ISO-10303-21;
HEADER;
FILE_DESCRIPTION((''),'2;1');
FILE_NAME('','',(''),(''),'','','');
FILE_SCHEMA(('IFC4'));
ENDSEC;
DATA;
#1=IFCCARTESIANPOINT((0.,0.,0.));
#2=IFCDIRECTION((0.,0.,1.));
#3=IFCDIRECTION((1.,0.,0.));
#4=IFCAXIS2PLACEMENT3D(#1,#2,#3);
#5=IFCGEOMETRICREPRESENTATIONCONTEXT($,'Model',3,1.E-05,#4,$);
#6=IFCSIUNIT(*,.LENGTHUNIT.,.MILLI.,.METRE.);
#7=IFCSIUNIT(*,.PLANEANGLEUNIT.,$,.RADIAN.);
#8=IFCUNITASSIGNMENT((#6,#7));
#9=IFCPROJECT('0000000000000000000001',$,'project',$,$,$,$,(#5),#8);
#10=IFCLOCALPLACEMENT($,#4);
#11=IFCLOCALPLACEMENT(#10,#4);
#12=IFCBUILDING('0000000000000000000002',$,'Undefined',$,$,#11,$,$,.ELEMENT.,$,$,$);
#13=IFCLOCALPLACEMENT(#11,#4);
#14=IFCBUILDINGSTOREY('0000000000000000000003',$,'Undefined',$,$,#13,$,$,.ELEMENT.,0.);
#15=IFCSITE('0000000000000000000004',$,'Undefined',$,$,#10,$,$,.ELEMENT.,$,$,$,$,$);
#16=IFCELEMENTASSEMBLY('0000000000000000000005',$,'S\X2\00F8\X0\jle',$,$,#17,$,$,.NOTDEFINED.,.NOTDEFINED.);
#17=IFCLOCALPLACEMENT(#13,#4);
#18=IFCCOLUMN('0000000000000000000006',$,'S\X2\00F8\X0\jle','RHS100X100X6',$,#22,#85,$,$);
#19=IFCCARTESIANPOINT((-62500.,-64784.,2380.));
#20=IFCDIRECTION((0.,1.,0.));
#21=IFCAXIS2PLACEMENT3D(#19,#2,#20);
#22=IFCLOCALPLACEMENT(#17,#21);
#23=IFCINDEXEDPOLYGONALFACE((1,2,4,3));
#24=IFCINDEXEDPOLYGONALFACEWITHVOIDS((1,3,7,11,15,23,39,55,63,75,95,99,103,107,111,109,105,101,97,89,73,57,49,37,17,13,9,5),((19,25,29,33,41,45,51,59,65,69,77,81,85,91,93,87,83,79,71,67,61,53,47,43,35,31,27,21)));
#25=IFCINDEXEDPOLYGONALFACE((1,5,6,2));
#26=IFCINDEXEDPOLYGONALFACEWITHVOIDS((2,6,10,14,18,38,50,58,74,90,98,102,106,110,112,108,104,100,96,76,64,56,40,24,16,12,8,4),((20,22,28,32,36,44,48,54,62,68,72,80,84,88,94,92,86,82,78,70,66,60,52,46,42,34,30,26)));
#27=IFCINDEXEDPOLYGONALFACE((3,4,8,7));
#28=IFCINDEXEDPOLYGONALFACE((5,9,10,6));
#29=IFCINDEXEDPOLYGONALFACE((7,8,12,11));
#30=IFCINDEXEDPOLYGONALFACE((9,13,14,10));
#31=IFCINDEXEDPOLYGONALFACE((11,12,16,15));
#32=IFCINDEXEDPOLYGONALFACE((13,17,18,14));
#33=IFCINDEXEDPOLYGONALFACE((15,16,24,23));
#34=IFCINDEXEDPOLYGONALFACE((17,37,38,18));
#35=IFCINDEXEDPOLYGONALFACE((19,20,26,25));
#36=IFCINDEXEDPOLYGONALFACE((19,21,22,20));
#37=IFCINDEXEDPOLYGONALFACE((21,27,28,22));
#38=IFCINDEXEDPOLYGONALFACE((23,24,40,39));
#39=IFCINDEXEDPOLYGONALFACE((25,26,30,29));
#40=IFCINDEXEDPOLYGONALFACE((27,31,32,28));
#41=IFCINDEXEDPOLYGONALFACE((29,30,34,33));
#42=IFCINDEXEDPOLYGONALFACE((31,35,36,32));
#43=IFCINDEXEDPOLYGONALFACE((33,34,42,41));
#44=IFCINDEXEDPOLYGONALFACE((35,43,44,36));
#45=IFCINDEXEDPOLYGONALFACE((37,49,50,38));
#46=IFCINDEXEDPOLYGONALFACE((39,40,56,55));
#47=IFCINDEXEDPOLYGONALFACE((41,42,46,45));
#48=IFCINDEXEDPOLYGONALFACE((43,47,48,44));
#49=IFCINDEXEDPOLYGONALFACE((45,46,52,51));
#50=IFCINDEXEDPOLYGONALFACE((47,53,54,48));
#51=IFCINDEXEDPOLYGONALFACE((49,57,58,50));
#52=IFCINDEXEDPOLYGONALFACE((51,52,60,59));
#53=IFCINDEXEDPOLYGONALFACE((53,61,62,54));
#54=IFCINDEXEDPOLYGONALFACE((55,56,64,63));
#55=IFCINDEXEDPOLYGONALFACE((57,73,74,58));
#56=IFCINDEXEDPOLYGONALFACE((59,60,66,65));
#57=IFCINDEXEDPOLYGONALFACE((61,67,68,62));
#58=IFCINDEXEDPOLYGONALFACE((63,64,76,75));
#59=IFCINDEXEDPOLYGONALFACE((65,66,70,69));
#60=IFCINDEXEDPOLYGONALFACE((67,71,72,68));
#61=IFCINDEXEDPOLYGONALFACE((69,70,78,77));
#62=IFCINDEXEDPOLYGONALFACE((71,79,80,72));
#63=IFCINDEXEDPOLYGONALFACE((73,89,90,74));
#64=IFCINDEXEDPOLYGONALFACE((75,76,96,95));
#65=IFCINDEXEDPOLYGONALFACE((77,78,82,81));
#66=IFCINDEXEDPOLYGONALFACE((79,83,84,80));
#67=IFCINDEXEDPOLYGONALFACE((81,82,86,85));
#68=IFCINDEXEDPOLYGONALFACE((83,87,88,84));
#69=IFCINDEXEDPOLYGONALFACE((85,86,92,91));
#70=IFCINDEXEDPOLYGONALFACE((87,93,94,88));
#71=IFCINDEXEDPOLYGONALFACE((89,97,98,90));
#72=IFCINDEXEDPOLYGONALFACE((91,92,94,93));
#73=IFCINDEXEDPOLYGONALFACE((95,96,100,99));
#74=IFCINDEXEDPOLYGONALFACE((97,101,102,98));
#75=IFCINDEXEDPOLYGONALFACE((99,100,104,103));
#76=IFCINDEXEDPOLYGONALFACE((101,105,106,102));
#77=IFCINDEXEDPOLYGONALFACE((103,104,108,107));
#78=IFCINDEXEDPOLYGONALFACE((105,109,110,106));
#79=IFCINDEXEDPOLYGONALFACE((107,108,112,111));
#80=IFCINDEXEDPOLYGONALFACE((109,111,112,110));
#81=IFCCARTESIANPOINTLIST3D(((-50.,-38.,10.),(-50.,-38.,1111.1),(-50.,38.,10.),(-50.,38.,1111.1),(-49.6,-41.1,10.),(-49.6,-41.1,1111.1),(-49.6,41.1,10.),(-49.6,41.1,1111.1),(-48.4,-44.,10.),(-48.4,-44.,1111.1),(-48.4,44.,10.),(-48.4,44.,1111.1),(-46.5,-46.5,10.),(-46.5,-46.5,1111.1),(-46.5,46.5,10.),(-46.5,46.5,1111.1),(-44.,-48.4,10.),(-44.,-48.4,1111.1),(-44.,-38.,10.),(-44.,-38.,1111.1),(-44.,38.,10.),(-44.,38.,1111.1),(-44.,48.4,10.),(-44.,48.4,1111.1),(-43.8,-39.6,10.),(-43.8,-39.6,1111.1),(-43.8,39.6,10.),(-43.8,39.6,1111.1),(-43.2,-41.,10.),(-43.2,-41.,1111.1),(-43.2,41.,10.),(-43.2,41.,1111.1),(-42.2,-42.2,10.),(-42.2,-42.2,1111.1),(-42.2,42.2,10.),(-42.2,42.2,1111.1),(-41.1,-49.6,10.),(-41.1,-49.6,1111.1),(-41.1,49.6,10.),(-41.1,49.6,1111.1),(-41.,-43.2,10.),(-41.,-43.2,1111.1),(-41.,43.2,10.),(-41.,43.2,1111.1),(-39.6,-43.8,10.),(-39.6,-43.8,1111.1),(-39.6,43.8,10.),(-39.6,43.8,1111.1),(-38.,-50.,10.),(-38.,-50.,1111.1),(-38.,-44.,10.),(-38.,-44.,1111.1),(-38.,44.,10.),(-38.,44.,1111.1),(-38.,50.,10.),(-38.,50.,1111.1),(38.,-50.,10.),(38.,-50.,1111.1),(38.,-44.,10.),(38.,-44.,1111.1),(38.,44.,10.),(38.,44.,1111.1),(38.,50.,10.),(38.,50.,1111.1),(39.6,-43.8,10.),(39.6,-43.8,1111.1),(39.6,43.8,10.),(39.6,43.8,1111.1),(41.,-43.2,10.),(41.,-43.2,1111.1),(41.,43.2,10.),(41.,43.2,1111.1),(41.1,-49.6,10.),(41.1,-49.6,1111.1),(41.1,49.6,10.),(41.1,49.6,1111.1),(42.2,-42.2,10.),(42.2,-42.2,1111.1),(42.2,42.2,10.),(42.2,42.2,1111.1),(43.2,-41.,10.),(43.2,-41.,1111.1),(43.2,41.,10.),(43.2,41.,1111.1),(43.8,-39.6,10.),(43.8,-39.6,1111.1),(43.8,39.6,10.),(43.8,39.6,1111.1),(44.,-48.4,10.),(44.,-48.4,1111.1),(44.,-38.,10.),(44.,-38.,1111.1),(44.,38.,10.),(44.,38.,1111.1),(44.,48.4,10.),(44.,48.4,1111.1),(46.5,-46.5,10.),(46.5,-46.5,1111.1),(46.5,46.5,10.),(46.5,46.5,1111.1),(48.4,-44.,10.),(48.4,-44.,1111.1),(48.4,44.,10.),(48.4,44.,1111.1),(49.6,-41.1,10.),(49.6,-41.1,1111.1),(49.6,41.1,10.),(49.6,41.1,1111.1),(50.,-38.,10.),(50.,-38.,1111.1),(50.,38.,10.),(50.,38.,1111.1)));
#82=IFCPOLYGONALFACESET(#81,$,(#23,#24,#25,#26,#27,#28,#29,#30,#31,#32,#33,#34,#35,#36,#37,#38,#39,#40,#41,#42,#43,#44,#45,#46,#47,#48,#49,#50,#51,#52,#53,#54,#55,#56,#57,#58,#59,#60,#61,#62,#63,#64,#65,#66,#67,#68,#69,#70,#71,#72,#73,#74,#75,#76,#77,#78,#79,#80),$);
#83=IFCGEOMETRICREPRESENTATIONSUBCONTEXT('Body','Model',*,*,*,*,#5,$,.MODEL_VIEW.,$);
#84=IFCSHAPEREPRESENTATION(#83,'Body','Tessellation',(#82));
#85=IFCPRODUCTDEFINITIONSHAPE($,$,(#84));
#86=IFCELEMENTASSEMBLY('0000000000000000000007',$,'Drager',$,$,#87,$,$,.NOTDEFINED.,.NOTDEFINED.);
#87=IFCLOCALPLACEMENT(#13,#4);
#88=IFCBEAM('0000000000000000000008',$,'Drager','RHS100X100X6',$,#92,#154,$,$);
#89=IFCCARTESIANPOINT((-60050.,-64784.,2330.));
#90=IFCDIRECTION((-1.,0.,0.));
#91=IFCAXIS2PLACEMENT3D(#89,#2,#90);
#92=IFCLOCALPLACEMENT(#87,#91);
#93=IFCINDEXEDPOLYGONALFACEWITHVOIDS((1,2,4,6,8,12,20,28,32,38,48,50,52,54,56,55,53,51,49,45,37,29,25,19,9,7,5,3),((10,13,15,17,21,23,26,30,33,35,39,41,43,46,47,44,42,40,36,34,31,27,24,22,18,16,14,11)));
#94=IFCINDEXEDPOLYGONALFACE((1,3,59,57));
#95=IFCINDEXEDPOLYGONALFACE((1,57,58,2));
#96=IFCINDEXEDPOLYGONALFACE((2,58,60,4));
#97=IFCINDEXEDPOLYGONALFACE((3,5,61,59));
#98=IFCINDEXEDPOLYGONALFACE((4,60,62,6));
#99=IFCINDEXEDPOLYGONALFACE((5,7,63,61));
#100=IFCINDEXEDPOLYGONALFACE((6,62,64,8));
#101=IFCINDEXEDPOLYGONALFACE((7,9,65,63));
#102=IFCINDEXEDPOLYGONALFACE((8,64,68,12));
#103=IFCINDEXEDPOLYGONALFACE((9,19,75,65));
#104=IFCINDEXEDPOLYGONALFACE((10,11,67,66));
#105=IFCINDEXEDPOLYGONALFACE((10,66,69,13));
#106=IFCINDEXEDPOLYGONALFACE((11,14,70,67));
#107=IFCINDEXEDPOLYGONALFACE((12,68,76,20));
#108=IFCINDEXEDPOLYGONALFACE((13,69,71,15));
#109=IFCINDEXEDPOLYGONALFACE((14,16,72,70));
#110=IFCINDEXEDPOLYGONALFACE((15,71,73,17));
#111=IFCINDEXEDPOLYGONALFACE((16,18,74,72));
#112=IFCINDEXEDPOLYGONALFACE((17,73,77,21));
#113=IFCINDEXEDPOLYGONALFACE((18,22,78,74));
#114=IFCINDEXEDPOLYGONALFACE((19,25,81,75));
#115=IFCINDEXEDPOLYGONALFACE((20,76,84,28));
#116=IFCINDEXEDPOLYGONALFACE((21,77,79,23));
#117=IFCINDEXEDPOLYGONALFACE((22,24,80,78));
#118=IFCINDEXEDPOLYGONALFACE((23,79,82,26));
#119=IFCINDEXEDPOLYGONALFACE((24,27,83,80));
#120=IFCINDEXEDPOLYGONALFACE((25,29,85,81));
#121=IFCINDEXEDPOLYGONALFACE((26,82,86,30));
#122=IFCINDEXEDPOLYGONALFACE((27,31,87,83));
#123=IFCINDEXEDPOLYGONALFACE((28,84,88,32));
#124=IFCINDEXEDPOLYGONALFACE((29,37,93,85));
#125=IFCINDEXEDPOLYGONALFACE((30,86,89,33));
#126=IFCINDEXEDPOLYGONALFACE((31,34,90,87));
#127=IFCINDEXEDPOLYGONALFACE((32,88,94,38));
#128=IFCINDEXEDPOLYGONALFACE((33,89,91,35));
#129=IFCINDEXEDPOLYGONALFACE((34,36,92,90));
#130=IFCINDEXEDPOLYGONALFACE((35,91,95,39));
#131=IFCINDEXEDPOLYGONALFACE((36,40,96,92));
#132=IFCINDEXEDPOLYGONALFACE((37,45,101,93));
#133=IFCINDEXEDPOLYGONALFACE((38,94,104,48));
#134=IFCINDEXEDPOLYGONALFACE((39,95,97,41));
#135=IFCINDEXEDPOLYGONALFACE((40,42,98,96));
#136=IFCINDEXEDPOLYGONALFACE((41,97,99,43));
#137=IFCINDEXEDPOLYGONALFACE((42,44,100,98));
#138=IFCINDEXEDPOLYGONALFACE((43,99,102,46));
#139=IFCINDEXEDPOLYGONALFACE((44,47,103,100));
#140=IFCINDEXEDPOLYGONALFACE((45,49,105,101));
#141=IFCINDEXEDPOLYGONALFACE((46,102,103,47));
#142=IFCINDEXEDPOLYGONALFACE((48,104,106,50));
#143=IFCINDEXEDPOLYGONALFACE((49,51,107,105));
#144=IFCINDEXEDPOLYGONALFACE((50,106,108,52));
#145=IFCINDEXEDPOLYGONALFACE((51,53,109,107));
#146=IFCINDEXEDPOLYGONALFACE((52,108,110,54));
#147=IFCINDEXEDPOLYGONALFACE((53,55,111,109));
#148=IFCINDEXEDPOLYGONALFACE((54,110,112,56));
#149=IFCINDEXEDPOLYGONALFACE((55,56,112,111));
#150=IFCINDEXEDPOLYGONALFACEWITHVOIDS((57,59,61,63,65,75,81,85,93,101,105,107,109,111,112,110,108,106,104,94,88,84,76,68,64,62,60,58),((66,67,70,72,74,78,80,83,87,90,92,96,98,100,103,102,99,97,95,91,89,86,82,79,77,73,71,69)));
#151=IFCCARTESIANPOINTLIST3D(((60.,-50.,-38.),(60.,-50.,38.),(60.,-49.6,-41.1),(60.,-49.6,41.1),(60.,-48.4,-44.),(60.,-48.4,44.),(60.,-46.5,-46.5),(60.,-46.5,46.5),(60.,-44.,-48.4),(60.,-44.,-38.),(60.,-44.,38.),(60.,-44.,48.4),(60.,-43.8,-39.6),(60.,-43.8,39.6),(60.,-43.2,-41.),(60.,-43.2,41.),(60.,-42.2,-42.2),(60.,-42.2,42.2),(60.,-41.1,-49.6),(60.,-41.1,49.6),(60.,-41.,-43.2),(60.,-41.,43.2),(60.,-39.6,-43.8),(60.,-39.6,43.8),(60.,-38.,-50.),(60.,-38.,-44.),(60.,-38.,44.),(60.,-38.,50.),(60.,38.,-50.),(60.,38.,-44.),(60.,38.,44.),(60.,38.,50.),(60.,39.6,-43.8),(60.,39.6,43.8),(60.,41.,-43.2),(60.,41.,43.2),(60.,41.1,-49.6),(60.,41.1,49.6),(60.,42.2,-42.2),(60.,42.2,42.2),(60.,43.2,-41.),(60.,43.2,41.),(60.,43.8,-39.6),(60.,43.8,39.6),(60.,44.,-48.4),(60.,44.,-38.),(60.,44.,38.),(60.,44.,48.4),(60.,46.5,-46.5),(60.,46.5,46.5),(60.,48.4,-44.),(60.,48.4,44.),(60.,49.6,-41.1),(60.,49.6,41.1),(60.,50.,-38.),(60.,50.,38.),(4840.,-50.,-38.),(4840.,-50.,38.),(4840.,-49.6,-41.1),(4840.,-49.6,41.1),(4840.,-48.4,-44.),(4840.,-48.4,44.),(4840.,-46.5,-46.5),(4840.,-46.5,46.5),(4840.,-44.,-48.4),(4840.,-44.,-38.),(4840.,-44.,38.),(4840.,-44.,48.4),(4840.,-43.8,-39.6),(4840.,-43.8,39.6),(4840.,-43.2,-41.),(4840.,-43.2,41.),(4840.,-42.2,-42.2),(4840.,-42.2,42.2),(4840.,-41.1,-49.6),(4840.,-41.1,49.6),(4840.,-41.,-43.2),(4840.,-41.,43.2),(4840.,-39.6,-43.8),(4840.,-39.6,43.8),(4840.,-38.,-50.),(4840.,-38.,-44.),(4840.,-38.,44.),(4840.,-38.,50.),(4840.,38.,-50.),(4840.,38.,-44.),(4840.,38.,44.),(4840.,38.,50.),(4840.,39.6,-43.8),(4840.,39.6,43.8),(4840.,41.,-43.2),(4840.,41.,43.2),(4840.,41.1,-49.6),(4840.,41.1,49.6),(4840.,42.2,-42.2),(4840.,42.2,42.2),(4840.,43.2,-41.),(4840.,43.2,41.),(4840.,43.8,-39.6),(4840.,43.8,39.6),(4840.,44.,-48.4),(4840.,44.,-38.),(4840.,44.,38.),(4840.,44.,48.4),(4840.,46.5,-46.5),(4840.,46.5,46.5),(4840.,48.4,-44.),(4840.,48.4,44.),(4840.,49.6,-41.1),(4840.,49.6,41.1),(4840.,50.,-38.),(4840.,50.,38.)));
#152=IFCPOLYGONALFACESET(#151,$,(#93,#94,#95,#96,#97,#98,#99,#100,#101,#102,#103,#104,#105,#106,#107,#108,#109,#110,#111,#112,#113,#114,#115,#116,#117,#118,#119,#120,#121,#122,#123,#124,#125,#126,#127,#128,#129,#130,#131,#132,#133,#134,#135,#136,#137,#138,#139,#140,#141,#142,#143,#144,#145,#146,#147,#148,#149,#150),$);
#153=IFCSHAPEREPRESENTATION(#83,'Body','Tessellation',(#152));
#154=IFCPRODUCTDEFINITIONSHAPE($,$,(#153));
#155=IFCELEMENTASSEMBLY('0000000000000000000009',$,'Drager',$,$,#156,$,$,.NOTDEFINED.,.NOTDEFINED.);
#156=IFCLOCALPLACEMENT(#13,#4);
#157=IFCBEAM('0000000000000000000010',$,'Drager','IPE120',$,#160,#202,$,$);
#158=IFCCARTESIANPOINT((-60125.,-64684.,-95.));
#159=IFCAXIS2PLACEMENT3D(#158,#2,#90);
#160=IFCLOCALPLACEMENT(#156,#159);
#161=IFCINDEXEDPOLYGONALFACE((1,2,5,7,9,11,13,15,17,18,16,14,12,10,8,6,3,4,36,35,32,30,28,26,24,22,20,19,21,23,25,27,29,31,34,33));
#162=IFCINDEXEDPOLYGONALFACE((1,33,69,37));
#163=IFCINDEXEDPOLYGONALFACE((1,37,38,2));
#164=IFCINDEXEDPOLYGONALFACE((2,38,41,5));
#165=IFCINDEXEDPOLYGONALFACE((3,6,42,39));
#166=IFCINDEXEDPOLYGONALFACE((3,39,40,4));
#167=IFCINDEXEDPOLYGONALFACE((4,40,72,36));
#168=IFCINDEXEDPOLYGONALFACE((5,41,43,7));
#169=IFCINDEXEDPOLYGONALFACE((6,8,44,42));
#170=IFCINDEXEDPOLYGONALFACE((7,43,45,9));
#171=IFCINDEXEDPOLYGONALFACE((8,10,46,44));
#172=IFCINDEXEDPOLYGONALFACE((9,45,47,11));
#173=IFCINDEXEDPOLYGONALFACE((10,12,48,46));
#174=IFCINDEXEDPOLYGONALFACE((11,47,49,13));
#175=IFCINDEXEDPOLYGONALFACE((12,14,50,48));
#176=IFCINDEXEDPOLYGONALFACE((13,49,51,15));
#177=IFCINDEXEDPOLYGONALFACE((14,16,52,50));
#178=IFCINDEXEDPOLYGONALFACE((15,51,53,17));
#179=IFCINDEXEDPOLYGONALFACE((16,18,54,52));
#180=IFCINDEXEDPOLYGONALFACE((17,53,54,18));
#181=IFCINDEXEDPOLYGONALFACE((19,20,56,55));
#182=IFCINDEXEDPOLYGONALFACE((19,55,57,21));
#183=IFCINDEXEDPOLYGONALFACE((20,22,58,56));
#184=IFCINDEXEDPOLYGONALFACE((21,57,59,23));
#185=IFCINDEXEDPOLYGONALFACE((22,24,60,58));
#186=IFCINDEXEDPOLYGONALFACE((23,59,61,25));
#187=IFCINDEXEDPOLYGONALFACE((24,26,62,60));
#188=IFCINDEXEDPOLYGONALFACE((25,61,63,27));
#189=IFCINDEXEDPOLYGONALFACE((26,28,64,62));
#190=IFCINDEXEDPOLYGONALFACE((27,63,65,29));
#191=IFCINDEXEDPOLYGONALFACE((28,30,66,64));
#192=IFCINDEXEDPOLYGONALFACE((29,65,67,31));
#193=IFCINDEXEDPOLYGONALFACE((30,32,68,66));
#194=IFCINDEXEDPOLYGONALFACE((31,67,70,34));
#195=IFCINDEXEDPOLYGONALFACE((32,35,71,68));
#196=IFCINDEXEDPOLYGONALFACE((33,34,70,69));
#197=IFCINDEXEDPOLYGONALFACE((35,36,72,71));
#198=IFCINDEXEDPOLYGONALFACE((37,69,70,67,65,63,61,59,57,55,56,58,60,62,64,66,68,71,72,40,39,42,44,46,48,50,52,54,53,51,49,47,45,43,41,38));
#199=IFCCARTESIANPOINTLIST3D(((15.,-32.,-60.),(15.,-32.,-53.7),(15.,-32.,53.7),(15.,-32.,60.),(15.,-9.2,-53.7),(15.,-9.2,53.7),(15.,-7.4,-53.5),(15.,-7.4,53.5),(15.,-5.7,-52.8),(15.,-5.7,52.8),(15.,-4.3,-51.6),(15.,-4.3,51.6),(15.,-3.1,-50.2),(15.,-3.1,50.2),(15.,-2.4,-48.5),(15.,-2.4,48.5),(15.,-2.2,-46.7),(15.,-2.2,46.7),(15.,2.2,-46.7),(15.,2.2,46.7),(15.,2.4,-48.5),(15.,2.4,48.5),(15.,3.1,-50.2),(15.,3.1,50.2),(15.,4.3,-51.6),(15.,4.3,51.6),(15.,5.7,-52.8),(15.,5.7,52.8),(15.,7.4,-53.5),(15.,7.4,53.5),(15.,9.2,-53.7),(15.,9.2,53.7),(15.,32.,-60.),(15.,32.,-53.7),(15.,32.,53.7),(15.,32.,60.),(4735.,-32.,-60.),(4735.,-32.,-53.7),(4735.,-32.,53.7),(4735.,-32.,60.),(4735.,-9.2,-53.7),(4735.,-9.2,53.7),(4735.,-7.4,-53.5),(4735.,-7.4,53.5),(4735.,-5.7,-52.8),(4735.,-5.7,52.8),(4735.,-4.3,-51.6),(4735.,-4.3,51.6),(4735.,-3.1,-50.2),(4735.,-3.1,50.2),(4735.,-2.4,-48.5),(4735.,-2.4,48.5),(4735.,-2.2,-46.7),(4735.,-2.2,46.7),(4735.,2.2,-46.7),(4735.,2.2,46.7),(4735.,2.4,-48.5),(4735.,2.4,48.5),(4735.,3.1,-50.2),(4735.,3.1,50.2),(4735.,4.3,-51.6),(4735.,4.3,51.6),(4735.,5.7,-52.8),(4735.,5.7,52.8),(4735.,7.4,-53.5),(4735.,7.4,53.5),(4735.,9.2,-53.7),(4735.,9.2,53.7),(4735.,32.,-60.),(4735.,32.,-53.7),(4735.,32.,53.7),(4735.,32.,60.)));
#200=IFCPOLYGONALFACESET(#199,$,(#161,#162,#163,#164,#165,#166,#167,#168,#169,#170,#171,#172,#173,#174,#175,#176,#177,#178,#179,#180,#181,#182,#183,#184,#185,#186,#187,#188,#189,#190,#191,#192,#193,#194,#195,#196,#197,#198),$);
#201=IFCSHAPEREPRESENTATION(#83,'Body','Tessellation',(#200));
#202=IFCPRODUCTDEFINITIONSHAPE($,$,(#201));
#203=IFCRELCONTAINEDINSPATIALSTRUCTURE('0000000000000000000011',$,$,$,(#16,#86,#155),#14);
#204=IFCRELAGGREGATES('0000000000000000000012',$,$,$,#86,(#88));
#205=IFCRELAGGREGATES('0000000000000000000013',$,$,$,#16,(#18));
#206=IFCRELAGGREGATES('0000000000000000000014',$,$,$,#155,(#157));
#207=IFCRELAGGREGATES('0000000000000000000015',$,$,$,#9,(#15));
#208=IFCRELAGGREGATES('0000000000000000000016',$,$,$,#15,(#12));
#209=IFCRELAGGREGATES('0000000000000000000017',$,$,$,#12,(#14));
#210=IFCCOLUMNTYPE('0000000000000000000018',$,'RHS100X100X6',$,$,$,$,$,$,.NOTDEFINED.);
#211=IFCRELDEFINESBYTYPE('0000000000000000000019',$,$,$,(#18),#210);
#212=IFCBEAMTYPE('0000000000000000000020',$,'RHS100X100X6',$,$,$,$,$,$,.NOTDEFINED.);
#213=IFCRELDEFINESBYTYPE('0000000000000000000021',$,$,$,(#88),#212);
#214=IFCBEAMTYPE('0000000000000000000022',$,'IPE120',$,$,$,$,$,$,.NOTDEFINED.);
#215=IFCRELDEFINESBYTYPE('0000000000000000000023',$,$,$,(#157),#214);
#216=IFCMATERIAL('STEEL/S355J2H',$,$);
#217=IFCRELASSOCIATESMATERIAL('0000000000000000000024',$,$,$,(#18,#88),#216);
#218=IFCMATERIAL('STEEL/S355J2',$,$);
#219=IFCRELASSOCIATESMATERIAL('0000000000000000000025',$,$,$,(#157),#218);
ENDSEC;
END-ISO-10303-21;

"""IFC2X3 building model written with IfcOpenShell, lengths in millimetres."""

from ifc_helpers import new_model, si_unit, frame, origin_with_axes, origin_2d_with_axis, place, context, subcontext, project, spatial, hollow_rectangle, i_section, extrude, clip, halfspace, material, type_object, element, aggregate, save


model = new_model("IFC2X3")

# Units and contexts
model_context = context("Model", 3, precision=1e-05, world=origin_with_axes())
body_context = subcontext(model_context, "Body", "Model", "MODEL_VIEW")
ifc_project = project(units=[si_unit("LENGTHUNIT", "METRE", prefix="MILLI"), si_unit("PLANEANGLEUNIT", "RADIAN")], contexts=[model_context])

# Site, building, storey
site_placement = place(None, origin_with_axes())
site = spatial("IfcSite", under=ifc_project, at=site_placement, Name="Undefined", CompositionType="ELEMENT")
building_placement = place(site_placement, origin_with_axes())
building = spatial("IfcBuilding", under=site, at=building_placement, Name="Undefined", CompositionType="ELEMENT")
storey_placement = place(building_placement, origin_with_axes())
storey = spatial("IfcBuildingStorey", under=building, at=storey_placement, Name="Undefined", CompositionType="ELEMENT", Elevation=0.0)

# Element assembly, column
assembly_1_placement = place(storey_placement, origin_with_axes())
assembly_1 = element("IfcElementAssembly", 1, at=assembly_1_placement, inside=storey, Name="Søjle", AssemblyPlace="NOTDEFINED", PredefinedType="NOTDEFINED")
ifc_material_1 = material(Name="STEEL/S355J2H")
column_type = type_object("IfcColumnType", Name="RHS100X100X6", PredefinedType="NOTDEFINED")
column_placement = place(assembly_1_placement, frame((-62500.0, -64784.0, 2380.0), z_axis=(0.0, 0.0, 1.0), x_axis=(0.0, 1.0, 0.0)))
column = element("IfcColumn", 2, at=column_placement, type_object=column_type, material=ifc_material_1, Name="Søjle", Description="RHS100X100X6", context=body_context, shape_type="Clipping", body=[
    clip(clip(extrude(hollow_rectangle(XDim=100.0, YDim=100.0, WallThickness=6.0, InnerFilletRadius=6.0, OuterFilletRadius=12.0, at=origin_2d_with_axis()), frame((0.0, 0.0, 1111.1), z_axis=(0.0, 0.0, -1.0), x_axis=(0.0, 1.0, 0.0)), (0.0, 0.0, 1.0), 1111.1), halfspace(frame((-50.0, 0.0, 1111.1), z_axis=(0.0, 0.0, -1.0), x_axis=(0.0, -1.0, 0.0)), True)), halfspace(frame((0.0, -50.0, 10.0), z_axis=(0.0, 0.0, 1.0), x_axis=(-1.0, 0.0, 0.0)), True)),
])

# Element assembly, beam
assembly_2_placement = place(storey_placement, origin_with_axes())
assembly_2 = element("IfcElementAssembly", 3, at=assembly_2_placement, inside=storey, Name="Drager", AssemblyPlace="NOTDEFINED", PredefinedType="NOTDEFINED")
beam_type_1 = type_object("IfcBeamType", Name="RHS100X100X6", PredefinedType="NOTDEFINED")
beam_1_placement = place(assembly_2_placement, frame((-60050.0, -64784.0, 2330.0), z_axis=(0.0, 0.0, 1.0), x_axis=(-1.0, 0.0, 0.0)))
beam_1 = element("IfcBeam", 4, at=beam_1_placement, type_object=beam_type_1, material=ifc_material_1, Name="Drager", Description="RHS100X100X6", context=body_context, shape_type="Clipping", body=[
    clip(clip(extrude(hollow_rectangle(XDim=100.0, YDim=100.0, WallThickness=6.0, InnerFilletRadius=6.0, OuterFilletRadius=12.0, at=origin_2d_with_axis()), frame((4900.0, 0.0, 0.0), z_axis=(-1.0, 0.0, 0.0), x_axis=(0.0, -1.0, 0.0)), (0.0, 0.0, 1.0), 4900.0), halfspace(frame((4840.0, 50.0, 0.0), z_axis=(-1.0, 0.0, 0.0), x_axis=(0.0, 0.0, 1.0)), True)), halfspace(frame((60.0, 50.0, 0.0), z_axis=(1.0, 0.0, 0.0), x_axis=(0.0, 0.0, -1.0)), True)),
])
ifc_material_2 = material(Name="STEEL/S355J2")

# Element assembly, beam
assembly_3_placement = place(storey_placement, origin_with_axes())
assembly_3 = element("IfcElementAssembly", 5, at=assembly_3_placement, inside=storey, Name="Drager", AssemblyPlace="NOTDEFINED", PredefinedType="NOTDEFINED")
beam_type_2 = type_object("IfcBeamType", Name="IPE120", PredefinedType="NOTDEFINED")
beam_2_placement = place(assembly_3_placement, frame((-60125.0, -64684.0, -95.0), z_axis=(0.0, 0.0, 1.0), x_axis=(-1.0, 0.0, 0.0)))
beam_2 = element("IfcBeam", 6, at=beam_2_placement, type_object=beam_type_2, material=ifc_material_2, Name="Drager", Description="IPE120", context=body_context, shape_type="Clipping", body=[
    clip(clip(extrude(i_section(OverallWidth=64.0, OverallDepth=120.0, WebThickness=4.4, FlangeThickness=6.3, FilletRadius=7.0, at=origin_2d_with_axis()), frame((4750.0, 0.0, 0.0), z_axis=(-1.0, 0.0, 0.0), x_axis=(0.0, -1.0, 0.0)), (0.0, 0.0, 1.0), 4750.0), halfspace(frame((4735.0, 0.0, -60.0), z_axis=(-1.0, 0.0, 0.0), x_axis=(0.0, 1.0, 0.0)), True)), halfspace(frame((15.0, 0.0, 60.0), z_axis=(1.0, 0.0, 0.0), x_axis=(0.0, 1.0, 0.0)), True)),
])

aggregate(assembly_2, [beam_1])
aggregate(assembly_1, [column])
aggregate(assembly_3, [beam_2])

save(model, "model.ifc")
